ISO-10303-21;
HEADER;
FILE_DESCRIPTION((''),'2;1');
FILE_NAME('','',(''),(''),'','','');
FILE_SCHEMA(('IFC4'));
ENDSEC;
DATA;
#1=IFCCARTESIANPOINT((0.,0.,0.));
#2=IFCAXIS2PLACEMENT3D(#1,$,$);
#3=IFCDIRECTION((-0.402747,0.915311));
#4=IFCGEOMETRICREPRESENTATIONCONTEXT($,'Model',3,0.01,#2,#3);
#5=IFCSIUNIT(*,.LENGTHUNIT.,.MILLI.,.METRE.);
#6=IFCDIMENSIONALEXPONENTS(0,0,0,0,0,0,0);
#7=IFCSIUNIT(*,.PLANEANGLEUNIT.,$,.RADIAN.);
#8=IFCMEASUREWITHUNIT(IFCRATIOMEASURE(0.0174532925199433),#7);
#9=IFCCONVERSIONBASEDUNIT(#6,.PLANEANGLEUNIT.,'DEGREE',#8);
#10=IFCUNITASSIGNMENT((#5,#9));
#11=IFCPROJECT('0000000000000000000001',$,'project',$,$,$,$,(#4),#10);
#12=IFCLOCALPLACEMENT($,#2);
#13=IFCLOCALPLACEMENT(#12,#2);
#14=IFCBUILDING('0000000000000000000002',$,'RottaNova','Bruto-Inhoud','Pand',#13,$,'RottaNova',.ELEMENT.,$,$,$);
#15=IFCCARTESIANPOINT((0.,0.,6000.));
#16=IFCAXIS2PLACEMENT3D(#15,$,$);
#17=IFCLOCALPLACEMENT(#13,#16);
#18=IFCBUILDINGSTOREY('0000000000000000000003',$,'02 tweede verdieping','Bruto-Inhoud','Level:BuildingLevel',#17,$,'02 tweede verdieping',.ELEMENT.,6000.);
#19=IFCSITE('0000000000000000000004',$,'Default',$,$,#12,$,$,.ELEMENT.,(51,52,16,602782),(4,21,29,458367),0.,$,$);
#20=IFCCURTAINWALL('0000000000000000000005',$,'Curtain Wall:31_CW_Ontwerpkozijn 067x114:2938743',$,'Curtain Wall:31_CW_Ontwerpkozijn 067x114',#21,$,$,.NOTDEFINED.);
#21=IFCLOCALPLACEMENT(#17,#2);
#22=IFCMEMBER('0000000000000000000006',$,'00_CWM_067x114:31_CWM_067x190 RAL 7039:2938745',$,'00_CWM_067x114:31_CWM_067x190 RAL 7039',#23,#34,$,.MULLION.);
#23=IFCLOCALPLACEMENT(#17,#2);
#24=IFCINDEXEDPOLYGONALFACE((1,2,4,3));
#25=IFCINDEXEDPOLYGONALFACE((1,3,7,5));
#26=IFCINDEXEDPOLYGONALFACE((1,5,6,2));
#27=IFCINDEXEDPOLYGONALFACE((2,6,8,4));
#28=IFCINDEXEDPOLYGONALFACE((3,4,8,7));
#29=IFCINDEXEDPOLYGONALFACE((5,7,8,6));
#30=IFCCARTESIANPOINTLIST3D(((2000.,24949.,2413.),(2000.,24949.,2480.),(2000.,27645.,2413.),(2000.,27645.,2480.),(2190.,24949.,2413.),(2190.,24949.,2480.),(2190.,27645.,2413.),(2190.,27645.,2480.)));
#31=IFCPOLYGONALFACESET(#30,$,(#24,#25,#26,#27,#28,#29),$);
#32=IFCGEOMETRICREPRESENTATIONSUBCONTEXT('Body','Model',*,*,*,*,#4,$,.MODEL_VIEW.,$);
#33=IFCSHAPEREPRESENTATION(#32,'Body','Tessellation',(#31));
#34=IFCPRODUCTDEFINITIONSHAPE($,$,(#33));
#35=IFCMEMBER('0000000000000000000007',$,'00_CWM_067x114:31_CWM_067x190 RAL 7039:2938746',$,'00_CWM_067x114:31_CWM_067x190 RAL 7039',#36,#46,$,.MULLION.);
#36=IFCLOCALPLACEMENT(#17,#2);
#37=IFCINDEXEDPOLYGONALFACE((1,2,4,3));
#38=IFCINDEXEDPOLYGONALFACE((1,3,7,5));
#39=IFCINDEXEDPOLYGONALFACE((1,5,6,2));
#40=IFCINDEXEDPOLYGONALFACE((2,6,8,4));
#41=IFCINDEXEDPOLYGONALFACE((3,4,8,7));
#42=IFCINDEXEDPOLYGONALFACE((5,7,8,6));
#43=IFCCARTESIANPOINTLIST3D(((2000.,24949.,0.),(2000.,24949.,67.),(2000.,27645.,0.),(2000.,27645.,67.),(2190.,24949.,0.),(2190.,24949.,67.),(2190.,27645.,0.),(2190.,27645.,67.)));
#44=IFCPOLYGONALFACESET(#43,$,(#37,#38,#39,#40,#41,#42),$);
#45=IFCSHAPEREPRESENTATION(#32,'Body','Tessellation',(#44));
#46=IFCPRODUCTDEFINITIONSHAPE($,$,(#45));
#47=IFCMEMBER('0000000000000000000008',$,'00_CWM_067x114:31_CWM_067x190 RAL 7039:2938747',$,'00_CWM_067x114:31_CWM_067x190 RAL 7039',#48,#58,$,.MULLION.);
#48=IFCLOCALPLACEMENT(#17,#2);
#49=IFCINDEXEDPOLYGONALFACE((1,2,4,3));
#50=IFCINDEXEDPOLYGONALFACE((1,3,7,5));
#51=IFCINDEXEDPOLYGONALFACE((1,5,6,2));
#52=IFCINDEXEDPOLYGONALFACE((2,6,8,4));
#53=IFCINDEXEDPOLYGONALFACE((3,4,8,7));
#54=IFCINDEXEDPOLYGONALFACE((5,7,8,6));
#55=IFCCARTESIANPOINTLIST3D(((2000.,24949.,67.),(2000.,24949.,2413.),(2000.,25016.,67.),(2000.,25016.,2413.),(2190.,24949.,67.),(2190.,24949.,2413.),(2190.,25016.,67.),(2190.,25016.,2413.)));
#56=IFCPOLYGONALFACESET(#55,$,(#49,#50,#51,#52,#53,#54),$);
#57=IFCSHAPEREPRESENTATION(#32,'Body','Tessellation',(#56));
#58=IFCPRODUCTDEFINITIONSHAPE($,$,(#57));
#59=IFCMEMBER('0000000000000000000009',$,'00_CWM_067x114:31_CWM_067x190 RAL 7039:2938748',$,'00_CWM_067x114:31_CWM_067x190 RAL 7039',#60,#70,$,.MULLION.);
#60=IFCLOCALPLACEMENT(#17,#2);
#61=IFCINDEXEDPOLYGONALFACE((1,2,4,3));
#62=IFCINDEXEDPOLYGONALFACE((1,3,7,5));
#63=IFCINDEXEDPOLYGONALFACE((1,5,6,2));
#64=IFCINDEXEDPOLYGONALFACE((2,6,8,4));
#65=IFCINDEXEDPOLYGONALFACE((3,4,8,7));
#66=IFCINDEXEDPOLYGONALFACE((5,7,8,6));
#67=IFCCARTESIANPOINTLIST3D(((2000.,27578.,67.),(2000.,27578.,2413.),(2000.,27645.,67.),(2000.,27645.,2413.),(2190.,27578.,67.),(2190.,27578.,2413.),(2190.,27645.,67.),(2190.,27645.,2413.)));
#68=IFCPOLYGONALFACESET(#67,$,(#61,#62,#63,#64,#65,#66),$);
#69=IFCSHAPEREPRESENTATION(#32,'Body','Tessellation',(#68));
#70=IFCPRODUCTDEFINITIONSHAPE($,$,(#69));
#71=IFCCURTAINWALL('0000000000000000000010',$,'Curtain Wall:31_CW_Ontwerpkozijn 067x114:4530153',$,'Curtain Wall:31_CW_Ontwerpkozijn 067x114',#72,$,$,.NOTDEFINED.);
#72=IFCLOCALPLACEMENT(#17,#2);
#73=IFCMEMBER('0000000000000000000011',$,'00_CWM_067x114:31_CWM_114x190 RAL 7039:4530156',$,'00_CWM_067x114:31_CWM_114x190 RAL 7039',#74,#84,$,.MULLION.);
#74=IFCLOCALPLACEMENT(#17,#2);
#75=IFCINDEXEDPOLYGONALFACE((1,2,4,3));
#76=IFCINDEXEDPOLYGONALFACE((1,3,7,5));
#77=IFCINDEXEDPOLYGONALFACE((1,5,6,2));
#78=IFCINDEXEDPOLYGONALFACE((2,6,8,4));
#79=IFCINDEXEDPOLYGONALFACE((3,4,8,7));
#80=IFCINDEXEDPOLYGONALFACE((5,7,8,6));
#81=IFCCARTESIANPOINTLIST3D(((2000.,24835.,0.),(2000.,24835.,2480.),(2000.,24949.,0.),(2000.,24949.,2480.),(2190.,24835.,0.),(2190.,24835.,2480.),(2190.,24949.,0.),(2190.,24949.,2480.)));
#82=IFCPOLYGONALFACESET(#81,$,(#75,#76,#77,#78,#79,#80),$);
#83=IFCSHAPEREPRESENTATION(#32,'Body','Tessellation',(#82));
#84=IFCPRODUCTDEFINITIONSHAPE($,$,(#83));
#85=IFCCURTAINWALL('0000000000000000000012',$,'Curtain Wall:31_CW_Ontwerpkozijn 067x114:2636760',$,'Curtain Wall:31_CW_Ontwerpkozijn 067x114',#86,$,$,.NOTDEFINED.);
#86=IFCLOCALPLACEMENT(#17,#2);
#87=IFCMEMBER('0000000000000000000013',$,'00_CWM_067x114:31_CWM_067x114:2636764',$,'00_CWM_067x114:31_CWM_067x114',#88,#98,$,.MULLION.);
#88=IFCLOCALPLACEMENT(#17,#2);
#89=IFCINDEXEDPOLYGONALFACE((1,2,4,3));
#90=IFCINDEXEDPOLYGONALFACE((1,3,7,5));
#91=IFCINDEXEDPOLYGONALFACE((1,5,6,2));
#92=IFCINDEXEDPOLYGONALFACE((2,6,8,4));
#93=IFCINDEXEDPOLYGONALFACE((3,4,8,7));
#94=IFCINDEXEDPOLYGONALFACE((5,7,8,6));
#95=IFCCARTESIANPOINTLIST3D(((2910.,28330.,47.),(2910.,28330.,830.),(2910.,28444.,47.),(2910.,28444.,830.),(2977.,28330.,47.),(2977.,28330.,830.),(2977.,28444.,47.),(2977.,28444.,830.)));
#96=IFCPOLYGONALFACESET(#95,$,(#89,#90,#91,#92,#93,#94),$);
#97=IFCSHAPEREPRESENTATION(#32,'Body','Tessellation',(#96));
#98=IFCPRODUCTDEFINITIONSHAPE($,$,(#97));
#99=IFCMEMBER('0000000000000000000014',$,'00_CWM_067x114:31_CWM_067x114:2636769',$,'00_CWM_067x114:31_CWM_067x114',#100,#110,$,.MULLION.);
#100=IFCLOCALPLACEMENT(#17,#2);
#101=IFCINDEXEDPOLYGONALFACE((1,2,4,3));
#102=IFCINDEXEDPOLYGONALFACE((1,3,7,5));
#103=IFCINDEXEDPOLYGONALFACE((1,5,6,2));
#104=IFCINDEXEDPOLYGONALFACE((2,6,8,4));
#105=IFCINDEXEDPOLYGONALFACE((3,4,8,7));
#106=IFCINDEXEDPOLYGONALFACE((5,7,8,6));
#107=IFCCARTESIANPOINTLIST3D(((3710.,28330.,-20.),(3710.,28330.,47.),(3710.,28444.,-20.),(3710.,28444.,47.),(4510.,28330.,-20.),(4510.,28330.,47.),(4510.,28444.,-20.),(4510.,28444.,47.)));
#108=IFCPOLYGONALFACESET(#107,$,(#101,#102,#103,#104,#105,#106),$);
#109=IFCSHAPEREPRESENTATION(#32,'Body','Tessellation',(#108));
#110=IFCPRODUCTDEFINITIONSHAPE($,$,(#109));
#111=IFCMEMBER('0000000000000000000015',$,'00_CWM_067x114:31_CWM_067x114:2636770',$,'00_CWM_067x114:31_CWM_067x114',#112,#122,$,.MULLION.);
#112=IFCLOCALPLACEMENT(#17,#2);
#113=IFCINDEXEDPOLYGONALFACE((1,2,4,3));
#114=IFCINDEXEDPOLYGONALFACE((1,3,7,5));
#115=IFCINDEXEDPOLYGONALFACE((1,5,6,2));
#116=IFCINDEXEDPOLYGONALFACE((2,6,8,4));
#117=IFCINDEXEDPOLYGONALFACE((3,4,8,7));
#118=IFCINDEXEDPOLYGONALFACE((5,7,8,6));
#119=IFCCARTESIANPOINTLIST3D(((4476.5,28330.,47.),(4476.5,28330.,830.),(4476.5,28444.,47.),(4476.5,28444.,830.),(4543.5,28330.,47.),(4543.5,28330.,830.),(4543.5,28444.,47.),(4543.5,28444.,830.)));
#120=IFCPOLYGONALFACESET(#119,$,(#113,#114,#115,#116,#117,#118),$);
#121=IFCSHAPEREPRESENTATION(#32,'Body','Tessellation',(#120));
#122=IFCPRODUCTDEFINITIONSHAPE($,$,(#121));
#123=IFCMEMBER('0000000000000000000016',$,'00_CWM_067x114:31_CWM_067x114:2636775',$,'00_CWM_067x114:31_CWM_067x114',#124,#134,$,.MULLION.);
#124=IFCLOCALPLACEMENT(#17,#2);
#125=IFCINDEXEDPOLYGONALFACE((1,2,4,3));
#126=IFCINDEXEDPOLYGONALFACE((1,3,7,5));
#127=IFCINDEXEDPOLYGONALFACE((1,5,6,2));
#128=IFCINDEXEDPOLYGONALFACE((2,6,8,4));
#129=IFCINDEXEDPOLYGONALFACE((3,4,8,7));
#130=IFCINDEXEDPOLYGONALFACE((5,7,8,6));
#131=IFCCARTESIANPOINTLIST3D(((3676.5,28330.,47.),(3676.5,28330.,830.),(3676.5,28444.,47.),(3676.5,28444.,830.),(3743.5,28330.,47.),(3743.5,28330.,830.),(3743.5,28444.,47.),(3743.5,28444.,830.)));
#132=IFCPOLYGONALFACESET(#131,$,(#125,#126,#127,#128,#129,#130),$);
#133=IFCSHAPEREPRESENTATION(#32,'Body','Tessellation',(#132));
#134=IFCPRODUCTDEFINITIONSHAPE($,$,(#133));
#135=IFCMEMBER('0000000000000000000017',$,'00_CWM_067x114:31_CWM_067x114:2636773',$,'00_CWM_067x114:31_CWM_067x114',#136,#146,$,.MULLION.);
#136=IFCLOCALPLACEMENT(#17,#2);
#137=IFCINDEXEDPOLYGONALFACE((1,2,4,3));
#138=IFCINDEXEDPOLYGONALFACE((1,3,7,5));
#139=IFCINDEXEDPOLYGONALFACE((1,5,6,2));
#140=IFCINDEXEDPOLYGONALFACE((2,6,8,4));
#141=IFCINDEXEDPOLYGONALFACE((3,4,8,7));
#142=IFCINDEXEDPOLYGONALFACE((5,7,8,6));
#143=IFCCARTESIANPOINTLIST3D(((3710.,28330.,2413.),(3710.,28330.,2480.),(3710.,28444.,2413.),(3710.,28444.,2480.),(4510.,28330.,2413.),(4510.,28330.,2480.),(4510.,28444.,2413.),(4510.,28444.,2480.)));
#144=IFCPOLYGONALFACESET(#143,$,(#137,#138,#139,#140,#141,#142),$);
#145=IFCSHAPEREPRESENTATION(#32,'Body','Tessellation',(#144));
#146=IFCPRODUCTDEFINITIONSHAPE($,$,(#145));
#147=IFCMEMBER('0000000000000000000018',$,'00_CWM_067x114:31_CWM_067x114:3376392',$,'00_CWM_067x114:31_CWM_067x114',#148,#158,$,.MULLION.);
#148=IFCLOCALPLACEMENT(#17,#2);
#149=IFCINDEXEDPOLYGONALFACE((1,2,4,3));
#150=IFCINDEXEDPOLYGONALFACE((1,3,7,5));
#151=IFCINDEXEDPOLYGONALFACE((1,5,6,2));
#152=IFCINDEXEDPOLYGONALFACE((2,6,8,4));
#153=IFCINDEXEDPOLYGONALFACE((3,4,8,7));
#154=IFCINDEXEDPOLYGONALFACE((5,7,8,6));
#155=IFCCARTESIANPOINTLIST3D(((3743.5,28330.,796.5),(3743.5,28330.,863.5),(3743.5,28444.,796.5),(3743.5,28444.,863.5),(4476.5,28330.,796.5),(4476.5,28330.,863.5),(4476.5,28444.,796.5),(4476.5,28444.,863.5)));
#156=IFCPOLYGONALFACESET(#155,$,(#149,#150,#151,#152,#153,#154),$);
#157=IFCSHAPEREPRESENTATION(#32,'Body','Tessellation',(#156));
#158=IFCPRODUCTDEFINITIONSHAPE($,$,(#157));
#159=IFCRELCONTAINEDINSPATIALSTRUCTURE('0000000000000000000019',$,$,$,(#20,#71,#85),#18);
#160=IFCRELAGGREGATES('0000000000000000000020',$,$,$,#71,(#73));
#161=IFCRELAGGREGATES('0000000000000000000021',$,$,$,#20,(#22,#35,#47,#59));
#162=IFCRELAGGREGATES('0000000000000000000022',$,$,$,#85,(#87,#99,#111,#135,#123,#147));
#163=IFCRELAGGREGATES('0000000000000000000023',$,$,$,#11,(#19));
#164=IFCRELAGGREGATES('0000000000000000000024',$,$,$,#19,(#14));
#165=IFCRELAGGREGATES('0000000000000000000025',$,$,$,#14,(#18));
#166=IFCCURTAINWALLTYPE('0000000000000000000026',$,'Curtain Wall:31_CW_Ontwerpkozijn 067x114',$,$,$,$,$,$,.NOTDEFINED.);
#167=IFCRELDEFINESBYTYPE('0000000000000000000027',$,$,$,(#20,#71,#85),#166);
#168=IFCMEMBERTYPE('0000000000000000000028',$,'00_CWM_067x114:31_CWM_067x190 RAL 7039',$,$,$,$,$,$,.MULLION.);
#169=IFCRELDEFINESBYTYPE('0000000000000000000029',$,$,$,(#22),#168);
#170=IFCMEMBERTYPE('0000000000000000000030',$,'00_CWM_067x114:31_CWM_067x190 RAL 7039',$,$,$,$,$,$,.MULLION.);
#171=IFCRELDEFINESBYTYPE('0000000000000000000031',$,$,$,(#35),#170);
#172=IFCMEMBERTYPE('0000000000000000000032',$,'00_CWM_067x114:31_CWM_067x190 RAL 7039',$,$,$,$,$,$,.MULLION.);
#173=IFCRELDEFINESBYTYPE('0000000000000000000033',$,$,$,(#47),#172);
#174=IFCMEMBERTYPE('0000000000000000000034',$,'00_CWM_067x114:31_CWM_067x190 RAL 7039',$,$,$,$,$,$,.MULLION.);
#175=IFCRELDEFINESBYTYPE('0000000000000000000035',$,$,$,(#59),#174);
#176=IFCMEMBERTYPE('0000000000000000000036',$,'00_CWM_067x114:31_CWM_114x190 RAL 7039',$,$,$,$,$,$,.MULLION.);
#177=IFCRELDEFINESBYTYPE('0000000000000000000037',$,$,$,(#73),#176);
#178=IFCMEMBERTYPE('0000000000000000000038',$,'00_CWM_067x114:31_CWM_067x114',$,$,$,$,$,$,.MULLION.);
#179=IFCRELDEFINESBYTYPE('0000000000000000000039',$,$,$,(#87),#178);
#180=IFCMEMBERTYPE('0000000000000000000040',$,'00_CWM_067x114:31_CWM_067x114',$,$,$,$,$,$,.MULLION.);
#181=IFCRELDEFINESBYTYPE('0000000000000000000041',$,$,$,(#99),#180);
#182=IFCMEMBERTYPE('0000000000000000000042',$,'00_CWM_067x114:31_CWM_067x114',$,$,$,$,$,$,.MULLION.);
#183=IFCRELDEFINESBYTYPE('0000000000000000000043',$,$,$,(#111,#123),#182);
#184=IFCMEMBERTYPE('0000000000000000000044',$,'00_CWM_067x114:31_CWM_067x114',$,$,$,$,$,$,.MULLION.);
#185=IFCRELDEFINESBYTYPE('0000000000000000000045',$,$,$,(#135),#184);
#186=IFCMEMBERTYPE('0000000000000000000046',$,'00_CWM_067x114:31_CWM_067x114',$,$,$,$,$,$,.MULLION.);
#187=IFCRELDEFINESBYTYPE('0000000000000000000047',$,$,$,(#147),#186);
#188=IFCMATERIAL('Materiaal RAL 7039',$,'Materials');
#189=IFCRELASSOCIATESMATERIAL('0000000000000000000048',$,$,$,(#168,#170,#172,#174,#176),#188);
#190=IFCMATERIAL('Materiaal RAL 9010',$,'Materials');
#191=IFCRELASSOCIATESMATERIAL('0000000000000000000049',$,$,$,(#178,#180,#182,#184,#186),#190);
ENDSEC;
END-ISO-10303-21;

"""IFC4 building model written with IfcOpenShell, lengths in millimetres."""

from ifc_helpers import new_model, entity, si_unit, converted_unit, direction, frame, origin, origin_2d_with_axis, place, context, subcontext, project, spatial, rectangle, extrude, source, transform, mapped, material, material_profile, profile_set, type_object, type_shapes, element, aggregate, save


model = new_model("IFC4")

# Units and contexts
model_context = context("Model", 3, precision=0.01, world=origin(), true_north=direction((-0.402747, 0.915311)))
body_context = subcontext(model_context, "Body", "Model", "MODEL_VIEW")
ifc_project = project(units=[si_unit("LENGTHUNIT", "METRE", prefix="MILLI"), converted_unit("PLANEANGLEUNIT", "DEGREE", entity("IfcRatioMeasure", 0.0174532925199433), si_unit("PLANEANGLEUNIT", "RADIAN"), dimensions=[0, 0, 0, 0, 0, 0, 0])], contexts=[model_context])

# Site, building, storey
site_placement = place(None, origin())
site = spatial("IfcSite", under=ifc_project, at=site_placement, Name="Default", CompositionType="ELEMENT", RefLatitude=(51, 52, 16, 602782), RefLongitude=(4, 21, 29, 458367), RefElevation=0.0)
building_placement = place(site_placement, origin())
building = spatial("IfcBuilding", under=site, at=building_placement, Name="RottaNova", Description="Bruto-Inhoud", ObjectType="Pand", LongName="RottaNova", CompositionType="ELEMENT")
storey_placement = place(building_placement, frame((0.0, 0.0, 6000.0)))
storey = spatial("IfcBuildingStorey", under=building, at=storey_placement, Name="02 tweede verdieping", Description="Bruto-Inhoud", ObjectType="Level:BuildingLevel", LongName="02 tweede verdieping", CompositionType="ELEMENT", Elevation=6000.0)

# Curtain wall, members
curtain_wall_type = type_object("IfcCurtainWallType", Name="Curtain Wall:31_CW_Ontwerpkozijn 067x114", PredefinedType="NOTDEFINED")
curtain_wall_1_placement = place(storey_placement, frame((0.0, 0.0, -6000.0)))
curtain_wall_1 = element("IfcCurtainWall", 1, at=curtain_wall_1_placement, inside=storey, type_object=curtain_wall_type, Name="Curtain Wall:31_CW_Ontwerpkozijn 067x114:2938743", ObjectType="Curtain Wall:31_CW_Ontwerpkozijn 067x114", PredefinedType="NOTDEFINED")
ifc_material_1 = material(Name="Materiaal RAL 7039", Category="Materials")
ifc_material_profile_1 = material_profile(ifc_material_1, rectangle(XDim=190.0, YDim=67.0, at=origin_2d_with_axis()), Name="31_CWM_067x190 RAL 7039")
ifc_profile_set_1 = profile_set([ifc_material_profile_1], Name="31_CWM_067x190 RAL 7039")
member_type_1 = type_object("IfcMemberType", Name="00_CWM_067x114:31_CWM_067x190 RAL 7039", PredefinedType="MULLION", material=ifc_profile_set_1)
shared_shape_1 = source(origin(), body_context, "Body", "SweptSolid", [
    extrude(rectangle(XDim=190.0, YDim=67.0, at=origin_2d_with_axis()), frame((-33.5, 95.0, -2696.0), z_axis=(0.0, 0.0, 1.0), x_axis=(0.0, -1.0, 0.0)), (0.0, 0.0, 1.0), 2696.0),
])
type_shapes(member_type_1, [shared_shape_1])
member_1_placement = place(curtain_wall_1_placement, frame((2190.0, 24949.0, 8480.0), z_axis=(0.0, -1.0, 0.0), x_axis=(0.0, 0.0, 1.0)))
member_1 = element("IfcMember", 2, at=member_1_placement, type_object=member_type_1, Name="00_CWM_067x114:31_CWM_067x190 RAL 7039:2938745", ObjectType="00_CWM_067x114:31_CWM_067x190 RAL 7039", PredefinedType="MULLION", context=body_context, shape_type="MappedRepresentation", body=[
    mapped(shared_shape_1, transform((0.0, 0.0, 0.0), scale=1.0)),
])
member_type_2 = type_object("IfcMemberType", Name="00_CWM_067x114:31_CWM_067x190 RAL 7039", PredefinedType="MULLION", material=ifc_profile_set_1)
shared_shape_2 = source(origin(), body_context, "Body", "SweptSolid", [
    extrude(rectangle(XDim=190.0, YDim=67.0, at=origin_2d_with_axis()), frame((-33.5, 95.0, -2696.0), z_axis=(0.0, 0.0, 1.0), x_axis=(0.0, -1.0, 0.0)), (0.0, 0.0, 1.0), 2696.0),
])
type_shapes(member_type_2, [shared_shape_2])
member_2_placement = place(curtain_wall_1_placement, frame((2190.0, 27645.0, 6000.0), z_axis=(0.0, 1.0, 0.0), x_axis=(0.0, 0.0, -1.0)))
member_2 = element("IfcMember", 3, at=member_2_placement, type_object=member_type_2, Name="00_CWM_067x114:31_CWM_067x190 RAL 7039:2938746", ObjectType="00_CWM_067x114:31_CWM_067x190 RAL 7039", PredefinedType="MULLION", context=body_context, shape_type="MappedRepresentation", body=[
    mapped(shared_shape_2, transform((0.0, 0.0, 0.0), scale=1.0)),
])
member_type_3 = type_object("IfcMemberType", Name="00_CWM_067x114:31_CWM_067x190 RAL 7039", PredefinedType="MULLION", material=ifc_profile_set_1)
shared_shape_3 = source(origin(), body_context, "Body", "SweptSolid", [
    extrude(rectangle(XDim=190.0, YDim=67.0, at=origin_2d_with_axis()), frame((-33.5, 95.0, -2346.0), z_axis=(0.0, 0.0, 1.0), x_axis=(0.0, -1.0, 0.0)), (0.0, 0.0, 1.0), 2346.0),
])
type_shapes(member_type_3, [shared_shape_3])
member_3_placement = place(curtain_wall_1_placement, frame((2190.0, 24949.0, 6067.0), z_axis=(0.0, 0.0, -1.0), x_axis=(0.0, -1.0, 0.0)))
member_3 = element("IfcMember", 4, at=member_3_placement, type_object=member_type_3, Name="00_CWM_067x114:31_CWM_067x190 RAL 7039:2938747", ObjectType="00_CWM_067x114:31_CWM_067x190 RAL 7039", PredefinedType="MULLION", context=body_context, shape_type="MappedRepresentation", body=[
    mapped(shared_shape_3, transform((0.0, 0.0, 0.0), scale=1.0)),
])
member_type_4 = type_object("IfcMemberType", Name="00_CWM_067x114:31_CWM_067x190 RAL 7039", PredefinedType="MULLION", material=ifc_profile_set_1)
shared_shape_4 = source(origin(), body_context, "Body", "SweptSolid", [
    extrude(rectangle(XDim=190.0, YDim=67.0, at=origin_2d_with_axis()), frame((-33.5, 95.0, -2346.0), z_axis=(0.0, 0.0, 1.0), x_axis=(0.0, -1.0, 0.0)), (0.0, 0.0, 1.0), 2346.0),
])
type_shapes(member_type_4, [shared_shape_4])
member_4_placement = place(curtain_wall_1_placement, frame((2190.0, 27645.0, 8413.0), z_axis=(0.0, 0.0, 1.0), x_axis=(0.0, 1.0, 0.0)))
member_4 = element("IfcMember", 5, at=member_4_placement, type_object=member_type_4, Name="00_CWM_067x114:31_CWM_067x190 RAL 7039:2938748", ObjectType="00_CWM_067x114:31_CWM_067x190 RAL 7039", PredefinedType="MULLION", context=body_context, shape_type="MappedRepresentation", body=[
    mapped(shared_shape_4, transform((0.0, 0.0, 0.0), scale=1.0)),
])

# Curtain wall, member
curtain_wall_2_placement = place(storey_placement, frame((0.0, 0.0, -6000.0)))
curtain_wall_2 = element("IfcCurtainWall", 6, at=curtain_wall_2_placement, inside=storey, type_object=curtain_wall_type, Name="Curtain Wall:31_CW_Ontwerpkozijn 067x114:4530153", ObjectType="Curtain Wall:31_CW_Ontwerpkozijn 067x114", PredefinedType="NOTDEFINED")
ifc_material_profile_2 = material_profile(ifc_material_1, rectangle(XDim=114.0, YDim=190.0, at=origin_2d_with_axis()), Name="31_CWM_114x190 RAL 7039")
ifc_profile_set_2 = profile_set([ifc_material_profile_2], Name="31_CWM_114x190 RAL 7039")
member_type_5 = type_object("IfcMemberType", Name="00_CWM_067x114:31_CWM_114x190 RAL 7039", PredefinedType="MULLION", material=ifc_profile_set_2)
shared_shape_5 = source(origin(), body_context, "Body", "SweptSolid", [
    extrude(rectangle(XDim=114.0, YDim=190.0, at=origin_2d_with_axis()), frame((-95.0, 0.0, -2480.0), z_axis=(0.0, 0.0, 1.0), x_axis=(0.0, -1.0, 0.0)), (0.0, 0.0, 1.0), 2480.0),
])
type_shapes(member_type_5, [shared_shape_5])
member_5_placement = place(curtain_wall_2_placement, frame((2190.0, 24892.0, 8480.0)))
member_5 = element("IfcMember", 7, at=member_5_placement, type_object=member_type_5, Name="00_CWM_067x114:31_CWM_114x190 RAL 7039:4530156", ObjectType="00_CWM_067x114:31_CWM_114x190 RAL 7039", PredefinedType="MULLION", context=body_context, shape_type="MappedRepresentation", body=[
    mapped(shared_shape_5, transform((0.0, 0.0, 0.0), scale=1.0)),
])
aggregate(curtain_wall_2, [member_5])

# Curtain wall, members
curtain_wall_3_placement = place(storey_placement, frame((0.0, 0.0, -6000.0)))
curtain_wall_3 = element("IfcCurtainWall", 8, at=curtain_wall_3_placement, inside=storey, type_object=curtain_wall_type, Name="Curtain Wall:31_CW_Ontwerpkozijn 067x114:2636760", ObjectType="Curtain Wall:31_CW_Ontwerpkozijn 067x114", PredefinedType="NOTDEFINED")
ifc_material_2 = material(Name="Materiaal RAL 9010", Category="Materials")
ifc_material_profile_3 = material_profile(ifc_material_2, rectangle(XDim=114.0, YDim=67.0, at=origin_2d_with_axis()), Name="31_CWM_067x114")
ifc_profile_set_3 = profile_set([ifc_material_profile_3], Name="31_CWM_067x114")
member_type_6 = type_object("IfcMemberType", Name="00_CWM_067x114:31_CWM_067x114", PredefinedType="MULLION", material=ifc_profile_set_3)
shared_shape_6 = source(origin(), body_context, "Body", "SweptSolid", [
    extrude(rectangle(XDim=114.0, YDim=67.0, at=origin_2d_with_axis()), frame((-33.5, 57.0, -783.0), z_axis=(0.0, 0.0, 1.0), x_axis=(0.0, -1.0, 0.0)), (0.0, 0.0, 1.0), 783.0),
])
type_shapes(member_type_6, [shared_shape_6])
member_6_placement = place(curtain_wall_3_placement, frame((2910.0, 28330.0, 6047.0), z_axis=(0.0, 0.0, -1.0), x_axis=(-1.0, 0.0, 0.0)))
member_6 = element("IfcMember", 9, at=member_6_placement, type_object=member_type_6, Name="00_CWM_067x114:31_CWM_067x114:2636764", ObjectType="00_CWM_067x114:31_CWM_067x114", PredefinedType="MULLION", context=body_context, shape_type="MappedRepresentation", body=[
    mapped(shared_shape_6, transform((0.0, 0.0, 0.0), scale=1.0)),
])
member_type_7 = type_object("IfcMemberType", Name="00_CWM_067x114:31_CWM_067x114", PredefinedType="MULLION", material=ifc_profile_set_3)
shared_shape_7 = source(origin(), body_context, "Body", "SweptSolid", [
    extrude(rectangle(XDim=114.0, YDim=67.0, at=origin_2d_with_axis()), frame((-33.5, 57.0, -800.0), z_axis=(0.0, 0.0, 1.0), x_axis=(0.0, -1.0, 0.0)), (0.0, 0.0, 1.0), 800.0),
])
type_shapes(member_type_7, [shared_shape_7])
member_7_placement = place(curtain_wall_3_placement, frame((4510.0, 28330.0, 5980.0), z_axis=(1.0, 0.0, 0.0), x_axis=(0.0, 0.0, -1.0)))
member_7 = element("IfcMember", 10, at=member_7_placement, type_object=member_type_7, Name="00_CWM_067x114:31_CWM_067x114:2636769", ObjectType="00_CWM_067x114:31_CWM_067x114", PredefinedType="MULLION", context=body_context, shape_type="MappedRepresentation", body=[
    mapped(shared_shape_7, transform((0.0, 0.0, 0.0), scale=1.0)),
])
member_type_8 = type_object("IfcMemberType", Name="00_CWM_067x114:31_CWM_067x114", PredefinedType="MULLION", material=ifc_profile_set_3)
shared_shape_8 = source(origin(), body_context, "Body", "SweptSolid", [
    extrude(rectangle(XDim=114.0, YDim=67.0, at=origin_2d_with_axis()), frame((0.0, 57.0, -783.0), z_axis=(0.0, 0.0, 1.0), x_axis=(0.0, -1.0, 0.0)), (0.0, 0.0, 1.0), 783.0),
])
type_shapes(member_type_8, [shared_shape_8])
member_8_placement = place(curtain_wall_3_placement, frame((4510.0, 28330.0, 6047.0), z_axis=(0.0, 0.0, -1.0), x_axis=(-1.0, 0.0, 0.0)))
member_8 = element("IfcMember", 11, at=member_8_placement, type_object=member_type_8, Name="00_CWM_067x114:31_CWM_067x114:2636770", ObjectType="00_CWM_067x114:31_CWM_067x114", PredefinedType="MULLION", context=body_context, shape_type="MappedRepresentation", body=[
    mapped(shared_shape_8, transform((0.0, 0.0, 0.0), scale=1.0)),
])
member_9_placement = place(curtain_wall_3_placement, frame((3710.0, 28330.0, 6047.0), z_axis=(0.0, 0.0, -1.0), x_axis=(-1.0, 0.0, 0.0)))
member_9 = element("IfcMember", 12, at=member_9_placement, type_object=member_type_8, Name="00_CWM_067x114:31_CWM_067x114:2636775", ObjectType="00_CWM_067x114:31_CWM_067x114", PredefinedType="MULLION", context=body_context, shape_type="MappedRepresentation", body=[
    mapped(shared_shape_8, transform((0.0, 0.0, 0.0), scale=1.0)),
])
member_type_9 = type_object("IfcMemberType", Name="00_CWM_067x114:31_CWM_067x114", PredefinedType="MULLION", material=ifc_profile_set_3)
shared_shape_9 = source(origin(), body_context, "Body", "SweptSolid", [
    extrude(rectangle(XDim=114.0, YDim=67.0, at=origin_2d_with_axis()), frame((-33.5, 57.0, -800.0), z_axis=(0.0, 0.0, 1.0), x_axis=(0.0, -1.0, 0.0)), (0.0, 0.0, 1.0), 800.0),
])
type_shapes(member_type_9, [shared_shape_9])
member_10_placement = place(curtain_wall_3_placement, frame((3710.0, 28330.0, 8480.0), z_axis=(-1.0, 0.0, 0.0), x_axis=(0.0, 0.0, 1.0)))
member_10 = element("IfcMember", 13, at=member_10_placement, type_object=member_type_9, Name="00_CWM_067x114:31_CWM_067x114:2636773", ObjectType="00_CWM_067x114:31_CWM_067x114", PredefinedType="MULLION", context=body_context, shape_type="MappedRepresentation", body=[
    mapped(shared_shape_9, transform((0.0, 0.0, 0.0), scale=1.0)),
])
member_type_10 = type_object("IfcMemberType", Name="00_CWM_067x114:31_CWM_067x114", PredefinedType="MULLION", material=ifc_profile_set_3)
shared_shape_10 = source(origin(), body_context, "Body", "SweptSolid", [
    extrude(rectangle(XDim=114.0, YDim=67.0, at=origin_2d_with_axis()), frame((0.0, 57.0, -733.0), z_axis=(0.0, 0.0, 1.0), x_axis=(0.0, -1.0, 0.0)), (0.0, 0.0, 1.0), 733.0),
])
type_shapes(member_type_10, [shared_shape_10])
member_11_placement = place(curtain_wall_3_placement, frame((3743.5, 28330.0, 6830.0), z_axis=(-1.0, 0.0, 0.0), x_axis=(0.0, 0.0, 1.0)))
member_11 = element("IfcMember", 14, at=member_11_placement, type_object=member_type_10, Name="00_CWM_067x114:31_CWM_067x114:3376392", ObjectType="00_CWM_067x114:31_CWM_067x114", PredefinedType="MULLION", context=body_context, shape_type="MappedRepresentation", body=[
    mapped(shared_shape_10, transform((0.0, 0.0, 0.0), scale=1.0)),
])

aggregate(curtain_wall_1, [member_1, member_2, member_3, member_4])

aggregate(curtain_wall_3, [member_6, member_7, member_8, member_10, member_9, member_11])

save(model, "model.ifc")
